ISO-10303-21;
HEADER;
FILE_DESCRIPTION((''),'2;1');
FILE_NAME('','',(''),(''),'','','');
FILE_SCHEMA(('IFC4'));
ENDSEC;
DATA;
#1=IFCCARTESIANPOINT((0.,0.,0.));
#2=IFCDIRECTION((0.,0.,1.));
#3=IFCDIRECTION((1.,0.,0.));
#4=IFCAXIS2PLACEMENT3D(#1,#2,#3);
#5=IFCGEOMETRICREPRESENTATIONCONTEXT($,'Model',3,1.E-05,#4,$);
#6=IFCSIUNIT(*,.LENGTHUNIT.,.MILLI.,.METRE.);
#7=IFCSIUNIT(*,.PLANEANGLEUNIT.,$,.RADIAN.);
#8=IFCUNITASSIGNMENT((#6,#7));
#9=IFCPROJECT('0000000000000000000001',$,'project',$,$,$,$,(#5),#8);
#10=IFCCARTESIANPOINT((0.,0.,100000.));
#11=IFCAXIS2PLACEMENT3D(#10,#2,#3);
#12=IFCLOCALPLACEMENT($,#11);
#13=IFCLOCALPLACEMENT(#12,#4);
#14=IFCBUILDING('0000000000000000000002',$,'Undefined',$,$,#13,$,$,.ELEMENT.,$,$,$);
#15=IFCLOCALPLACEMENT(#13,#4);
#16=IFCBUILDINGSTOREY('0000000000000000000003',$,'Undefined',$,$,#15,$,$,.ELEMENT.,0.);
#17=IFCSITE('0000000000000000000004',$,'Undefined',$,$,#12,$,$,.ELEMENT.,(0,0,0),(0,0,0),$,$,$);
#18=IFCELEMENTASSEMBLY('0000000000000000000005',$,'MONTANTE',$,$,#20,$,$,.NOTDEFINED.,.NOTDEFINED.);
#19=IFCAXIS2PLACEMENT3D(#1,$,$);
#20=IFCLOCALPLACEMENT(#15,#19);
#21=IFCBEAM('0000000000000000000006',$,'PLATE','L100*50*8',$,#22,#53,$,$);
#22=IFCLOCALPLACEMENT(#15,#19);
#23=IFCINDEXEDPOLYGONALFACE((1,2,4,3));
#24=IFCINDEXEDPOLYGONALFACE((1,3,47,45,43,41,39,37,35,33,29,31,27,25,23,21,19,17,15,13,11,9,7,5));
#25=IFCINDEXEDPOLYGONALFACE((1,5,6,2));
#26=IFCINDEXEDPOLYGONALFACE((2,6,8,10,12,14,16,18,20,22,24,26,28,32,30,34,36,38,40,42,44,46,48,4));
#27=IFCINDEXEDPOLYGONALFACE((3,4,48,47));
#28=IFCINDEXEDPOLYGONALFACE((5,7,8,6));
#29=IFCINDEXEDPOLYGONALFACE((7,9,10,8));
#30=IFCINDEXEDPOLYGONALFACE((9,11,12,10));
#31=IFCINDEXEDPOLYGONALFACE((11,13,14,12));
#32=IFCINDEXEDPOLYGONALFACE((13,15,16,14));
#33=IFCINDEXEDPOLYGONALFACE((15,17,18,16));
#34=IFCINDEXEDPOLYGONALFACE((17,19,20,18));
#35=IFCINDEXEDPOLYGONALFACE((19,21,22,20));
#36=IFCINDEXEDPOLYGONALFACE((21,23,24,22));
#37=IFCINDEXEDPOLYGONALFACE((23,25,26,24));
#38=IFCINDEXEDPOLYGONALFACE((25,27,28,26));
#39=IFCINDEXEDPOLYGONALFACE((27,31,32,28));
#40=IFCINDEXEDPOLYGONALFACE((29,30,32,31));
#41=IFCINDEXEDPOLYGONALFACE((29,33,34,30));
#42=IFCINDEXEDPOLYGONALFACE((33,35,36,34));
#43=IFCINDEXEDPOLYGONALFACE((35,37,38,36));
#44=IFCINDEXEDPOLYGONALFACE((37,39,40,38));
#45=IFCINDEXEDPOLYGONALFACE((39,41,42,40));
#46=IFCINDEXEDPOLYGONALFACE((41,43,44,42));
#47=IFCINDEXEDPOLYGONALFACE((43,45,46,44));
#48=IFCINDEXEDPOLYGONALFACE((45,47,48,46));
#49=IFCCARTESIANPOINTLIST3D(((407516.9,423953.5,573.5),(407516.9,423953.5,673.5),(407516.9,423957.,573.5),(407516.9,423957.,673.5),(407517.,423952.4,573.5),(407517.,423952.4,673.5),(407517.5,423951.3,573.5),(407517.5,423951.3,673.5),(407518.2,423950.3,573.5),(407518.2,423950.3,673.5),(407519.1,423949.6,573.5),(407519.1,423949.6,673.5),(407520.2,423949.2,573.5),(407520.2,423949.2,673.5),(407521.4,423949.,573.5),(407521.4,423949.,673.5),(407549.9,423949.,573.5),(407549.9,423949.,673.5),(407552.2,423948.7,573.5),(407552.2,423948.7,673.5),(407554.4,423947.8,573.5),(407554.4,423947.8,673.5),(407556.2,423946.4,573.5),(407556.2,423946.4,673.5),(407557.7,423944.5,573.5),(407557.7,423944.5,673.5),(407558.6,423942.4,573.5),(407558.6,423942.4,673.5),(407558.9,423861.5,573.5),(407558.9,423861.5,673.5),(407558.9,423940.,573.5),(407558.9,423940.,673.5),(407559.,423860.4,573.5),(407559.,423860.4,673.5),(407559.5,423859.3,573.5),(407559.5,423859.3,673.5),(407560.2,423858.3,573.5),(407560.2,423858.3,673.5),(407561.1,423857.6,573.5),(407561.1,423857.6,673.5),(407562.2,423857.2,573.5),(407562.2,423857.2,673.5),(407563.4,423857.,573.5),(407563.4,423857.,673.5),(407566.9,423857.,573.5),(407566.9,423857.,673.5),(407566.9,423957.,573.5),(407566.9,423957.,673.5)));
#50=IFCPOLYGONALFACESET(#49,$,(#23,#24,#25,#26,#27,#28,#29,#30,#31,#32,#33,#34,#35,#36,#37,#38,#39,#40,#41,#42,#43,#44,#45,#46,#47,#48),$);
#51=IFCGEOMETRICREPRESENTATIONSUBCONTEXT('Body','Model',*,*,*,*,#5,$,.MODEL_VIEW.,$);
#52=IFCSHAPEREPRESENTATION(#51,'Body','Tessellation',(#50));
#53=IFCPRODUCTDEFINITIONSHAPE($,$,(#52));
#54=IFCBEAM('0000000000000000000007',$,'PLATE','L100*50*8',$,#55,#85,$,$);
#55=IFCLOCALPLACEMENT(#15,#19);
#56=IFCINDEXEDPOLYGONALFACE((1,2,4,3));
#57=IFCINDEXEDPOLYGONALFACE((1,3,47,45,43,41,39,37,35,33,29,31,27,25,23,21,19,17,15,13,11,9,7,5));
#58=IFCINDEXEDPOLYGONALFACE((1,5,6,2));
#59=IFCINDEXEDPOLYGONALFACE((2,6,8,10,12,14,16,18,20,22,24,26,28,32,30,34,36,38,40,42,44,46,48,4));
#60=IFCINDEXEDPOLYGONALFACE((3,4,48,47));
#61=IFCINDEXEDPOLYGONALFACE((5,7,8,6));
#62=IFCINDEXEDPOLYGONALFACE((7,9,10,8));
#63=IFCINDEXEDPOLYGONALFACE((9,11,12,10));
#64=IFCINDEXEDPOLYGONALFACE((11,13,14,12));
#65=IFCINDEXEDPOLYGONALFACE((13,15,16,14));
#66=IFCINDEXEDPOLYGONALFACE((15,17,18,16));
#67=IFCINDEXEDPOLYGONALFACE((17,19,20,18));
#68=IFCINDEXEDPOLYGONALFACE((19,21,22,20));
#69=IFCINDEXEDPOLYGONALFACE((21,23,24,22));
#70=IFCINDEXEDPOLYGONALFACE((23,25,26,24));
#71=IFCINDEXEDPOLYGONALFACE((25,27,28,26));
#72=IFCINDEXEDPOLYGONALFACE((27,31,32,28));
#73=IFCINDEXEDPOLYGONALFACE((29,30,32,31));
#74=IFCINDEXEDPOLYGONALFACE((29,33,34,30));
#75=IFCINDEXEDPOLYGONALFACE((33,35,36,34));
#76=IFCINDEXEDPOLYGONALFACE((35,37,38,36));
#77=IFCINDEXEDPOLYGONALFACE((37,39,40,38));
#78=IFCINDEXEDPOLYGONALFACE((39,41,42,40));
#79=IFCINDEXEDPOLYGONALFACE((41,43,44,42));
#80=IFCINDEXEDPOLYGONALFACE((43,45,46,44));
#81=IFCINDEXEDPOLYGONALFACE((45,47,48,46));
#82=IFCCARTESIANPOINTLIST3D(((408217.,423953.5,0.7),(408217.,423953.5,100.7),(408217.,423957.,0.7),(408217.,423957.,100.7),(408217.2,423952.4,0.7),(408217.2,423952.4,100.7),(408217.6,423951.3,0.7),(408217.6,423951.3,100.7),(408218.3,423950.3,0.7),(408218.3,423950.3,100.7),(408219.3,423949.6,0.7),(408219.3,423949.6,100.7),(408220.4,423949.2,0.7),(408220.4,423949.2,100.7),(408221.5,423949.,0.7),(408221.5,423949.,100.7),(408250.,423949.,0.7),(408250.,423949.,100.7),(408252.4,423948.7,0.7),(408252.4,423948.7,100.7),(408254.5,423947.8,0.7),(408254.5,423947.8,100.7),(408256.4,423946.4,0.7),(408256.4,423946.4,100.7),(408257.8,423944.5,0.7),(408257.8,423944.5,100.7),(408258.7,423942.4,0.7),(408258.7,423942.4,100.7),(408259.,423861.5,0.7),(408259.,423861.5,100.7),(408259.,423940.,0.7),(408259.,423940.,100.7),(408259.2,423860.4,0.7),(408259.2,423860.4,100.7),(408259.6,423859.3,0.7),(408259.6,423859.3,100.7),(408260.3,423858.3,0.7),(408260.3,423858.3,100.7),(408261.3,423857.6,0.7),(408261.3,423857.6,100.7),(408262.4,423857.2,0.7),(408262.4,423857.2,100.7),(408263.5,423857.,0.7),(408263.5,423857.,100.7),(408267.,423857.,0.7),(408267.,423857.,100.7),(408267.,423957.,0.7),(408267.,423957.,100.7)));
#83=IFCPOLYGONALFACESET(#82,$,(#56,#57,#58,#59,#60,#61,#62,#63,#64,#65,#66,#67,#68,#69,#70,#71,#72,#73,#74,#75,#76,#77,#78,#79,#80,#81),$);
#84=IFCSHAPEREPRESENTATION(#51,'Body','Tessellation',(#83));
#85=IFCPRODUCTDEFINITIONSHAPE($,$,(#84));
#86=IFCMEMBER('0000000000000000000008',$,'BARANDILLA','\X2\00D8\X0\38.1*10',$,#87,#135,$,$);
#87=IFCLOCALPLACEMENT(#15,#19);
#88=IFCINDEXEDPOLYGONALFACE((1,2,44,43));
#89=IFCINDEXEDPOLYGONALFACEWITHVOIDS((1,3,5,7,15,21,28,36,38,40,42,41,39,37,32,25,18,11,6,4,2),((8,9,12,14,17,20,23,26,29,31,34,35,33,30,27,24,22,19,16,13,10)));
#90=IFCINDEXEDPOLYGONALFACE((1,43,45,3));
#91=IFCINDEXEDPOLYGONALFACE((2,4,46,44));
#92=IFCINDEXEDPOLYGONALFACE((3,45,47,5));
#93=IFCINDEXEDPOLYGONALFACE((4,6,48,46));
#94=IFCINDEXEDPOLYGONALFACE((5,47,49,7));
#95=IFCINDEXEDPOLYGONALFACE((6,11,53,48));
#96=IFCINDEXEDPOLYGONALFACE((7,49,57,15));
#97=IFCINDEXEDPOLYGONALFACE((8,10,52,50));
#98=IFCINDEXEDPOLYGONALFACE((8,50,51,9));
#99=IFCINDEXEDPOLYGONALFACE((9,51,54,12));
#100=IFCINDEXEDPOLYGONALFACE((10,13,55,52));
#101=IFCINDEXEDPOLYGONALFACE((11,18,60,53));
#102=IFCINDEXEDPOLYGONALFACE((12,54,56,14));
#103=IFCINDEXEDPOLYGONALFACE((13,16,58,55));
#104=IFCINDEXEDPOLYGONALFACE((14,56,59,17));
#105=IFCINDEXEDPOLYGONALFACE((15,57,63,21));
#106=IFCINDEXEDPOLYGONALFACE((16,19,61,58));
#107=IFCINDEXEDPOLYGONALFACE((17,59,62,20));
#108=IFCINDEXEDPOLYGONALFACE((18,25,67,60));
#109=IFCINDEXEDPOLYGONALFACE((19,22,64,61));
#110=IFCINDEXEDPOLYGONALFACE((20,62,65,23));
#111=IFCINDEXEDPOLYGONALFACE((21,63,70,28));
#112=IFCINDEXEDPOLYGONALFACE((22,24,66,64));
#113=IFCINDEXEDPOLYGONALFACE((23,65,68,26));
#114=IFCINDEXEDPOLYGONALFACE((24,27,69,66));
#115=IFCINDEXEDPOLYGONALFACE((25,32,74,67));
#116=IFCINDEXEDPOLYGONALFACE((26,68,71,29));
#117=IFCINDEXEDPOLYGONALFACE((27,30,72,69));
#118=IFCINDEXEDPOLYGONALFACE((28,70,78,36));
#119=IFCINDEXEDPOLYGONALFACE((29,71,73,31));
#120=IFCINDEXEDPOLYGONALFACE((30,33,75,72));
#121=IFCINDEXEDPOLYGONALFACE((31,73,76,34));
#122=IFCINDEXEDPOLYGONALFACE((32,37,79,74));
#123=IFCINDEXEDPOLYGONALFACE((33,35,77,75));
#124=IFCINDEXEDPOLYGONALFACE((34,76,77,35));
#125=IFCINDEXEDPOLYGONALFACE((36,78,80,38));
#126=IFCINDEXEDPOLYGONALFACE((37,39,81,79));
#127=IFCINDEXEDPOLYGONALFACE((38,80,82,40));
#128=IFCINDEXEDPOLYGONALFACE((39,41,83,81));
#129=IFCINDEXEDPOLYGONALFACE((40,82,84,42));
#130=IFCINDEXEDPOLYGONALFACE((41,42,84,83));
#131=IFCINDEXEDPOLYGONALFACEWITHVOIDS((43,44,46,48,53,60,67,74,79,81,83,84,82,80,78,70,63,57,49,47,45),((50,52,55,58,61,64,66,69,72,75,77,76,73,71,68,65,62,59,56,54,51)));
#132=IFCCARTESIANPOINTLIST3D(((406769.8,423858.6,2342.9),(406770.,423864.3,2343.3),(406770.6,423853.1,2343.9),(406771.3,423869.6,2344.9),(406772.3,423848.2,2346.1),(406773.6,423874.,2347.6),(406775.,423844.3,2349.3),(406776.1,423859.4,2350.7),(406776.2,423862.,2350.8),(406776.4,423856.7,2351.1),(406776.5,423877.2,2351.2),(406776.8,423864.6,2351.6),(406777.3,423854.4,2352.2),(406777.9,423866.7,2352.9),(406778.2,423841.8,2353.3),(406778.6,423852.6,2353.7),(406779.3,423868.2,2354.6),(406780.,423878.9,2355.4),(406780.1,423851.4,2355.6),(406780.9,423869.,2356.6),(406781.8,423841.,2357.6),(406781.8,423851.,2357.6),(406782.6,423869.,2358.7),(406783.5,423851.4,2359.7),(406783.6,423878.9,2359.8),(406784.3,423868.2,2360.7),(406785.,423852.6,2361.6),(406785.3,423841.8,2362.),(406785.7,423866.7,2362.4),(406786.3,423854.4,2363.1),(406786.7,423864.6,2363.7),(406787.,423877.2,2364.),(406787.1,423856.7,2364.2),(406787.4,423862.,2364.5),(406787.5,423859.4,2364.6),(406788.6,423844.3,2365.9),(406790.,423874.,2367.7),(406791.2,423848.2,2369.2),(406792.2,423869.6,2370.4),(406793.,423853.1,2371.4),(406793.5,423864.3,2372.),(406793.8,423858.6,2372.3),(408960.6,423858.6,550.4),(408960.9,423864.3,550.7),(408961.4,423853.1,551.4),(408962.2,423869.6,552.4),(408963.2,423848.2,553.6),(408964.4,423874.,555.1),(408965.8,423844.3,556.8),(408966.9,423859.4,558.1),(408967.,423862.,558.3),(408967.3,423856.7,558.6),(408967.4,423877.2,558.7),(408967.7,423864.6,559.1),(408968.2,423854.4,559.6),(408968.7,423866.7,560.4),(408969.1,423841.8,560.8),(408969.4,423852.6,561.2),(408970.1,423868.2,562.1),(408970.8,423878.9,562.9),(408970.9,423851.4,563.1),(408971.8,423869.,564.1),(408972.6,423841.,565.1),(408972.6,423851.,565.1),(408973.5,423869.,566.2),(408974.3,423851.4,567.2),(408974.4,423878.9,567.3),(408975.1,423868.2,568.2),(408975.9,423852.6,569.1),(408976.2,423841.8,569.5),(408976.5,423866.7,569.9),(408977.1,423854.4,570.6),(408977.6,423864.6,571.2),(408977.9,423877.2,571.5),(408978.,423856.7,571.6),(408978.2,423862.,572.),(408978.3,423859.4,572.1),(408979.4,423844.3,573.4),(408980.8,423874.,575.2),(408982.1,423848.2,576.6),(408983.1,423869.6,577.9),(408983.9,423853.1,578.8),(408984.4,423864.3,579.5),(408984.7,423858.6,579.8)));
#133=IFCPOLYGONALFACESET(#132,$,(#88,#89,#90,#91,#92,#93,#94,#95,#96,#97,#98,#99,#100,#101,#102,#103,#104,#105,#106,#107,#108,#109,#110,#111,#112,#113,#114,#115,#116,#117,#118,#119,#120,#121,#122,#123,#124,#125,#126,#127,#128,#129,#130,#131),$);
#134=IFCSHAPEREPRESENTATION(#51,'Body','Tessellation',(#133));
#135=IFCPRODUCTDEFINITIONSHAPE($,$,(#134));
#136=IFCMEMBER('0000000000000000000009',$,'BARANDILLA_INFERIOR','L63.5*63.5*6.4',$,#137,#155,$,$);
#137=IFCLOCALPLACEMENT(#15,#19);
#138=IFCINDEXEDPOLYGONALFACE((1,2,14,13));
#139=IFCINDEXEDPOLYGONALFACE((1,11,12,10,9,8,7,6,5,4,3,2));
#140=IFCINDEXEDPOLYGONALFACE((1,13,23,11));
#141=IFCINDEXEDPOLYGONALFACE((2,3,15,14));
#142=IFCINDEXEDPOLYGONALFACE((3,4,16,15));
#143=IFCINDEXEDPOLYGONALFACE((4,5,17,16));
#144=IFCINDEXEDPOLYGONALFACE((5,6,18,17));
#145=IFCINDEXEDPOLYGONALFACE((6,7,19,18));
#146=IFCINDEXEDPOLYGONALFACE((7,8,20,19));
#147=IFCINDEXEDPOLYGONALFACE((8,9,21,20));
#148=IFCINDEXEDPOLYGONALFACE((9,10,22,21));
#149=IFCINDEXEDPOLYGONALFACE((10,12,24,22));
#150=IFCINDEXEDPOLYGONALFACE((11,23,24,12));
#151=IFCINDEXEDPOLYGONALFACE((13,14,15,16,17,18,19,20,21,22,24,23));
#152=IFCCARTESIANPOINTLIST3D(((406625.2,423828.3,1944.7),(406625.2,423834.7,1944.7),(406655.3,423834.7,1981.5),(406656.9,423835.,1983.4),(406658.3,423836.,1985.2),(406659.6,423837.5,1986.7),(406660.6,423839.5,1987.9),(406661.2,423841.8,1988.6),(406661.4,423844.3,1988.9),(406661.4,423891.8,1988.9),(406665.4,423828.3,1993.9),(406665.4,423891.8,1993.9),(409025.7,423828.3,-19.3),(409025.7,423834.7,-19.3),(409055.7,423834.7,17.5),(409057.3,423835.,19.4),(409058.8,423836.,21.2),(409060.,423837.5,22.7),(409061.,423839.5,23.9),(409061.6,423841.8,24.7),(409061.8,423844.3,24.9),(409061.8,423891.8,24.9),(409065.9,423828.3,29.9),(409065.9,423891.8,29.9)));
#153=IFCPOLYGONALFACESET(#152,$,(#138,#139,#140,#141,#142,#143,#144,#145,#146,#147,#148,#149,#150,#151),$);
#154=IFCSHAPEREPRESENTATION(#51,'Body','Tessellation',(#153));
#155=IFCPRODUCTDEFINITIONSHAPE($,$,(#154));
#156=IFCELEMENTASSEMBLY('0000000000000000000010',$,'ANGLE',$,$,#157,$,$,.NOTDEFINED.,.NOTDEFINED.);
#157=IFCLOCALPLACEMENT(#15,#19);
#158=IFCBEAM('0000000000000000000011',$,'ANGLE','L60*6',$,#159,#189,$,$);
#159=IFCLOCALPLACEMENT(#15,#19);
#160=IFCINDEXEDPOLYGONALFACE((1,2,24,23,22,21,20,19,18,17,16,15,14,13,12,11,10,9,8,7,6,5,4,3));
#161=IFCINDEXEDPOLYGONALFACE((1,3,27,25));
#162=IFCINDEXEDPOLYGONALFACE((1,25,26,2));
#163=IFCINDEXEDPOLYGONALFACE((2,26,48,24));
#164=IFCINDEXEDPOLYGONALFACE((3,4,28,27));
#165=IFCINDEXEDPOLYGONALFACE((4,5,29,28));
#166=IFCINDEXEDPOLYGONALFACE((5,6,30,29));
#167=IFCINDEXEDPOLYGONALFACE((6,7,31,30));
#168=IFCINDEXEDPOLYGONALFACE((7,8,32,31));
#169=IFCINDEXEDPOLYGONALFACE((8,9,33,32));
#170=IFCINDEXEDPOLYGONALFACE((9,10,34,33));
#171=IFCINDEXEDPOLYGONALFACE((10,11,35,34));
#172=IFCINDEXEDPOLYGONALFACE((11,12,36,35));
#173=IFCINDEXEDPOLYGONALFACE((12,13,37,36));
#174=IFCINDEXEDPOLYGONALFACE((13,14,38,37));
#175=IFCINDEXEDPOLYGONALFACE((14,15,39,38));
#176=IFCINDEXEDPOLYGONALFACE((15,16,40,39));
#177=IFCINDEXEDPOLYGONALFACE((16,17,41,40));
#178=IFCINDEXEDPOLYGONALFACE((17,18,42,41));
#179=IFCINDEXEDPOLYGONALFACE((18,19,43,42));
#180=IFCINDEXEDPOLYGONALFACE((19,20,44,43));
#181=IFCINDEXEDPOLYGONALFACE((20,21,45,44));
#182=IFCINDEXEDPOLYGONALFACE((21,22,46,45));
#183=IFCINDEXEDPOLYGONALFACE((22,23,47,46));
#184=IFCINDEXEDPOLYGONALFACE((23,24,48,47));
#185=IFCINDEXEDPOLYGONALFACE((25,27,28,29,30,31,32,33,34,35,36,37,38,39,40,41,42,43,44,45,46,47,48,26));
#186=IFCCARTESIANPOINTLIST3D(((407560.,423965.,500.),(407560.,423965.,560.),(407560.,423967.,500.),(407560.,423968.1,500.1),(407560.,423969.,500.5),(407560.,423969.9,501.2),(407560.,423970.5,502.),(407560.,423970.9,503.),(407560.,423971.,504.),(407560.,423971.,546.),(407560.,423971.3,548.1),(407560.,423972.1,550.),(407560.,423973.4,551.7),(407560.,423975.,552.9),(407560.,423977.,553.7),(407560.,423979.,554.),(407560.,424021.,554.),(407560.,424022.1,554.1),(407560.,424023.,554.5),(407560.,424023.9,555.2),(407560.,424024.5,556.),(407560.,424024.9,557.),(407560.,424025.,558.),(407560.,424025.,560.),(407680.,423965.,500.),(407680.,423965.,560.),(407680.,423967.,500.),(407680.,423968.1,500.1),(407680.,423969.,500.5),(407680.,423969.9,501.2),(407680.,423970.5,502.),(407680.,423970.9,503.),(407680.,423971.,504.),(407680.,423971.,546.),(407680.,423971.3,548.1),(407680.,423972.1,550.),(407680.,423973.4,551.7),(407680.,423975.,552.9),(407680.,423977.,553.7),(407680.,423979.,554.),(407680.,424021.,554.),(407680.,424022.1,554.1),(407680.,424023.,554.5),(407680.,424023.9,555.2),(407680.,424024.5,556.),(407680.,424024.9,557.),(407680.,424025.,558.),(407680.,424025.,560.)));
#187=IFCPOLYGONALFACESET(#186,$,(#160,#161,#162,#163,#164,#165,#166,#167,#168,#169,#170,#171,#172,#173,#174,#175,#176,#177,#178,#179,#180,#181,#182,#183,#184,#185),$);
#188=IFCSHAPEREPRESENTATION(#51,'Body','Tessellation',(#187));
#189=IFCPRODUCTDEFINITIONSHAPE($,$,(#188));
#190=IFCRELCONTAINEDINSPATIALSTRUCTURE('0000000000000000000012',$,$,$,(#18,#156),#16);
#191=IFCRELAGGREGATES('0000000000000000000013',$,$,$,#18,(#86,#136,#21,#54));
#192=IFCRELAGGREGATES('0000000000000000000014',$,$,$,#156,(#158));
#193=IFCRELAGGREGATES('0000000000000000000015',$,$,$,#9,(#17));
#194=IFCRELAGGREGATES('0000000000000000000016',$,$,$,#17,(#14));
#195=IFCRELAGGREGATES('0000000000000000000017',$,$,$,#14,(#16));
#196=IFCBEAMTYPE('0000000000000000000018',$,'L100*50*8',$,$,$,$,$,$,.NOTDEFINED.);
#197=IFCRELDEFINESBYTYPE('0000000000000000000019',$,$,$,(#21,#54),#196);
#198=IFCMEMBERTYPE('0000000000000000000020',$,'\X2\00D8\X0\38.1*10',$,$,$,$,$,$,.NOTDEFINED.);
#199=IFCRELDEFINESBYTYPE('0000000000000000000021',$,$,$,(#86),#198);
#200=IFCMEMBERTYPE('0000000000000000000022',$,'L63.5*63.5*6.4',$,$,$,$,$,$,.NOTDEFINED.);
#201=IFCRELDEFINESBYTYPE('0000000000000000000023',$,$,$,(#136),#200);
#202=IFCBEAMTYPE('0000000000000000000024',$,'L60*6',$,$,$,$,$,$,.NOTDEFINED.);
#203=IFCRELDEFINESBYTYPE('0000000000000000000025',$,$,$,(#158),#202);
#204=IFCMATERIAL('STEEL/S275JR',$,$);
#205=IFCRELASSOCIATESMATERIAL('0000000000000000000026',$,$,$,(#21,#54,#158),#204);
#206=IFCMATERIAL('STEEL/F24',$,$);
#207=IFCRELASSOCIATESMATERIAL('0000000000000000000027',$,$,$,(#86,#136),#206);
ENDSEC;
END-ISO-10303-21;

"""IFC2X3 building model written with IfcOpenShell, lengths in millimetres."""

from ifc_helpers import new_model, si_unit, frame, origin_with_axes, origin_2d_with_axis, place, context, subcontext, project, spatial, hollow_circle, l_section, extrude, clip, halfspace, material, type_object, element, aggregate, save


model = new_model("IFC2X3")

# Units and contexts
model_context = context("Model", 3, precision=1e-05, world=origin_with_axes())
body_context = subcontext(model_context, "Body", "Model", "MODEL_VIEW")
ifc_project = project(units=[si_unit("LENGTHUNIT", "METRE", prefix="MILLI"), si_unit("PLANEANGLEUNIT", "RADIAN")], contexts=[model_context])

# Site, building, storey
site_placement = place(None, frame((0.0, 0.0, 100000.0), z_axis=(0.0, 0.0, 1.0), x_axis=(1.0, 0.0, 0.0)))
site = spatial("IfcSite", under=ifc_project, at=site_placement, Name="Undefined", CompositionType="ELEMENT", RefLatitude=(0, 0, 0), RefLongitude=(0, 0, 0))
building_placement = place(site_placement, origin_with_axes())
building = spatial("IfcBuilding", under=site, at=building_placement, Name="Undefined", CompositionType="ELEMENT")
storey_placement = place(building_placement, origin_with_axes())
storey = spatial("IfcBuildingStorey", under=building, at=storey_placement, Name="Undefined", CompositionType="ELEMENT", Elevation=0.0)

# Element assembly, beams, members
assembly_1_placement = place(storey_placement, origin_with_axes())
assembly_1 = element("IfcElementAssembly", 1, at=assembly_1_placement, inside=storey, Name="MONTANTE", AssemblyPlace="NOTDEFINED", PredefinedType="NOTDEFINED")
ifc_material_1 = material(Name="STEEL/F24")
ifc_material_2 = material(Name="STEEL/S275JR")
beam_type_1 = type_object("IfcBeamType", Name="L100*50*8", PredefinedType="NOTDEFINED")
beam_1_placement = place(assembly_1_placement, frame((407541.9, 423907.0, 673.5), z_axis=(0.0, -1.0, 0.0), x_axis=(0.0, 0.0, -1.0)))
beam_1 = element("IfcBeam", 2, at=beam_1_placement, type_object=beam_type_1, material=ifc_material_2, Name="PLATE", Description="L100*50*8", context=body_context, shape_type="SweptSolid", body=[
    extrude(l_section(Depth=100.0, Width=50.0, Thickness=8.0, FilletRadius=9.0, EdgeRadius=4.5, at=origin_2d_with_axis()), frame((100.0, 0.0, 0.0), z_axis=(-1.0, 0.0, 0.0), x_axis=(0.0, -1.0, 0.0)), (0.0, 0.0, 1.0), 100.0),
])
beam_2_placement = place(assembly_1_placement, frame((408242.0, 423907.0, 100.7), z_axis=(0.0, -1.0, 0.0), x_axis=(0.0, 0.0, -1.0)))
beam_2 = element("IfcBeam", 3, at=beam_2_placement, type_object=beam_type_1, material=ifc_material_2, Name="PLATE", Description="L100*50*8", context=body_context, shape_type="SweptSolid", body=[
    extrude(l_section(Depth=100.0, Width=50.0, Thickness=8.0, FilletRadius=9.0, EdgeRadius=4.5, at=origin_2d_with_axis()), frame((100.0, 0.0, 0.0), z_axis=(-1.0, 0.0, 0.0), x_axis=(0.0, -1.0, 0.0)), (0.0, 0.0, 1.0), 100.0),
])
member_type_1 = type_object("IfcMemberType", Name="Ø38.1*10", PredefinedType="NOTDEFINED")
member_1_placement = place(assembly_1_placement, frame((408972.6, 423860.0, 565.1), z_axis=(-0.633238, 0.0, -0.773957), x_axis=(-0.773957, 0.0, 0.633238)))
member_1 = element("IfcMember", 4, at=member_1_placement, type_object=member_type_1, material=ifc_material_1, Name="BARANDILLA", Description="Ø38.1*10", context=body_context, shape_type="Clipping", body=[
    clip(clip(extrude(hollow_circle(Radius=19.1, WallThickness=10.0, at=origin_2d_with_axis()), frame((2868.4, 0.0, 0.0), z_axis=(-1.0, 0.0, 0.0), x_axis=(0.0, -1.0, 0.0)), (0.0, 0.0, 1.0), 2906.2), halfspace(frame((2830.7, 0.0, 0.0), z_axis=(1.0, 0.0, 0.0), x_axis=(0.0, -1.0, 0.0)), False)), halfspace(frame((0.0, 0.0, 0.0), z_axis=(1.0, 0.0, 0.0), x_axis=(0.0, -1.0, 0.0)), True)),
])
member_type_2 = type_object("IfcMemberType", Name="L63.5*63.5*6.4", PredefinedType="NOTDEFINED")
member_2_placement = place(assembly_1_placement, frame((409045.8, 423860.0, 5.3), z_axis=(0.0, 1.0, 0.0), x_axis=(-0.773957, 0.0, 0.633238)))
member_2 = element("IfcMember", 5, at=member_2_placement, type_object=member_type_2, material=ifc_material_1, Name="BARANDILLA_INFERIOR", Description="L63.5*63.5*6.4", context=body_context, shape_type="SweptSolid", body=[
    extrude(l_section(Depth=63.5, Width=63.5, Thickness=6.4, FilletRadius=9.6, at=origin_2d_with_axis()), frame((3101.5, 0.0, 0.0), z_axis=(-1.0, 0.0, 0.0), x_axis=(0.0, -1.0, 0.0)), (0.0, 0.0, 1.0), 3101.5),
])

# Element assembly, beam
assembly_2_placement = place(storey_placement, origin_with_axes())
assembly_2 = element("IfcElementAssembly", 6, at=assembly_2_placement, inside=storey, Name="ANGLE", AssemblyPlace="NOTDEFINED", PredefinedType="NOTDEFINED")
beam_type_2 = type_object("IfcBeamType", Name="L60*6", PredefinedType="NOTDEFINED")
beam_3_placement = place(assembly_2_placement, frame((407680.0, 423995.0, 530.0), z_axis=(0.0, 1.0, 0.0), x_axis=(-1.0, 0.0, 0.0)))
beam_3 = element("IfcBeam", 7, at=beam_3_placement, type_object=beam_type_2, material=ifc_material_2, Name="ANGLE", Description="L60*6", context=body_context, shape_type="SweptSolid", body=[
    extrude(l_section(Depth=60.0, Width=60.0, Thickness=6.0, FilletRadius=8.0, EdgeRadius=4.0, at=origin_2d_with_axis()), frame((120.0, 0.0, 0.0), z_axis=(-1.0, 0.0, 0.0), x_axis=(0.0, -1.0, 0.0)), (0.0, 0.0, 1.0), 120.0),
])

aggregate(assembly_1, [member_1, member_2, beam_1, beam_2])

aggregate(assembly_2, [beam_3])

save(model, "model.ifc")
